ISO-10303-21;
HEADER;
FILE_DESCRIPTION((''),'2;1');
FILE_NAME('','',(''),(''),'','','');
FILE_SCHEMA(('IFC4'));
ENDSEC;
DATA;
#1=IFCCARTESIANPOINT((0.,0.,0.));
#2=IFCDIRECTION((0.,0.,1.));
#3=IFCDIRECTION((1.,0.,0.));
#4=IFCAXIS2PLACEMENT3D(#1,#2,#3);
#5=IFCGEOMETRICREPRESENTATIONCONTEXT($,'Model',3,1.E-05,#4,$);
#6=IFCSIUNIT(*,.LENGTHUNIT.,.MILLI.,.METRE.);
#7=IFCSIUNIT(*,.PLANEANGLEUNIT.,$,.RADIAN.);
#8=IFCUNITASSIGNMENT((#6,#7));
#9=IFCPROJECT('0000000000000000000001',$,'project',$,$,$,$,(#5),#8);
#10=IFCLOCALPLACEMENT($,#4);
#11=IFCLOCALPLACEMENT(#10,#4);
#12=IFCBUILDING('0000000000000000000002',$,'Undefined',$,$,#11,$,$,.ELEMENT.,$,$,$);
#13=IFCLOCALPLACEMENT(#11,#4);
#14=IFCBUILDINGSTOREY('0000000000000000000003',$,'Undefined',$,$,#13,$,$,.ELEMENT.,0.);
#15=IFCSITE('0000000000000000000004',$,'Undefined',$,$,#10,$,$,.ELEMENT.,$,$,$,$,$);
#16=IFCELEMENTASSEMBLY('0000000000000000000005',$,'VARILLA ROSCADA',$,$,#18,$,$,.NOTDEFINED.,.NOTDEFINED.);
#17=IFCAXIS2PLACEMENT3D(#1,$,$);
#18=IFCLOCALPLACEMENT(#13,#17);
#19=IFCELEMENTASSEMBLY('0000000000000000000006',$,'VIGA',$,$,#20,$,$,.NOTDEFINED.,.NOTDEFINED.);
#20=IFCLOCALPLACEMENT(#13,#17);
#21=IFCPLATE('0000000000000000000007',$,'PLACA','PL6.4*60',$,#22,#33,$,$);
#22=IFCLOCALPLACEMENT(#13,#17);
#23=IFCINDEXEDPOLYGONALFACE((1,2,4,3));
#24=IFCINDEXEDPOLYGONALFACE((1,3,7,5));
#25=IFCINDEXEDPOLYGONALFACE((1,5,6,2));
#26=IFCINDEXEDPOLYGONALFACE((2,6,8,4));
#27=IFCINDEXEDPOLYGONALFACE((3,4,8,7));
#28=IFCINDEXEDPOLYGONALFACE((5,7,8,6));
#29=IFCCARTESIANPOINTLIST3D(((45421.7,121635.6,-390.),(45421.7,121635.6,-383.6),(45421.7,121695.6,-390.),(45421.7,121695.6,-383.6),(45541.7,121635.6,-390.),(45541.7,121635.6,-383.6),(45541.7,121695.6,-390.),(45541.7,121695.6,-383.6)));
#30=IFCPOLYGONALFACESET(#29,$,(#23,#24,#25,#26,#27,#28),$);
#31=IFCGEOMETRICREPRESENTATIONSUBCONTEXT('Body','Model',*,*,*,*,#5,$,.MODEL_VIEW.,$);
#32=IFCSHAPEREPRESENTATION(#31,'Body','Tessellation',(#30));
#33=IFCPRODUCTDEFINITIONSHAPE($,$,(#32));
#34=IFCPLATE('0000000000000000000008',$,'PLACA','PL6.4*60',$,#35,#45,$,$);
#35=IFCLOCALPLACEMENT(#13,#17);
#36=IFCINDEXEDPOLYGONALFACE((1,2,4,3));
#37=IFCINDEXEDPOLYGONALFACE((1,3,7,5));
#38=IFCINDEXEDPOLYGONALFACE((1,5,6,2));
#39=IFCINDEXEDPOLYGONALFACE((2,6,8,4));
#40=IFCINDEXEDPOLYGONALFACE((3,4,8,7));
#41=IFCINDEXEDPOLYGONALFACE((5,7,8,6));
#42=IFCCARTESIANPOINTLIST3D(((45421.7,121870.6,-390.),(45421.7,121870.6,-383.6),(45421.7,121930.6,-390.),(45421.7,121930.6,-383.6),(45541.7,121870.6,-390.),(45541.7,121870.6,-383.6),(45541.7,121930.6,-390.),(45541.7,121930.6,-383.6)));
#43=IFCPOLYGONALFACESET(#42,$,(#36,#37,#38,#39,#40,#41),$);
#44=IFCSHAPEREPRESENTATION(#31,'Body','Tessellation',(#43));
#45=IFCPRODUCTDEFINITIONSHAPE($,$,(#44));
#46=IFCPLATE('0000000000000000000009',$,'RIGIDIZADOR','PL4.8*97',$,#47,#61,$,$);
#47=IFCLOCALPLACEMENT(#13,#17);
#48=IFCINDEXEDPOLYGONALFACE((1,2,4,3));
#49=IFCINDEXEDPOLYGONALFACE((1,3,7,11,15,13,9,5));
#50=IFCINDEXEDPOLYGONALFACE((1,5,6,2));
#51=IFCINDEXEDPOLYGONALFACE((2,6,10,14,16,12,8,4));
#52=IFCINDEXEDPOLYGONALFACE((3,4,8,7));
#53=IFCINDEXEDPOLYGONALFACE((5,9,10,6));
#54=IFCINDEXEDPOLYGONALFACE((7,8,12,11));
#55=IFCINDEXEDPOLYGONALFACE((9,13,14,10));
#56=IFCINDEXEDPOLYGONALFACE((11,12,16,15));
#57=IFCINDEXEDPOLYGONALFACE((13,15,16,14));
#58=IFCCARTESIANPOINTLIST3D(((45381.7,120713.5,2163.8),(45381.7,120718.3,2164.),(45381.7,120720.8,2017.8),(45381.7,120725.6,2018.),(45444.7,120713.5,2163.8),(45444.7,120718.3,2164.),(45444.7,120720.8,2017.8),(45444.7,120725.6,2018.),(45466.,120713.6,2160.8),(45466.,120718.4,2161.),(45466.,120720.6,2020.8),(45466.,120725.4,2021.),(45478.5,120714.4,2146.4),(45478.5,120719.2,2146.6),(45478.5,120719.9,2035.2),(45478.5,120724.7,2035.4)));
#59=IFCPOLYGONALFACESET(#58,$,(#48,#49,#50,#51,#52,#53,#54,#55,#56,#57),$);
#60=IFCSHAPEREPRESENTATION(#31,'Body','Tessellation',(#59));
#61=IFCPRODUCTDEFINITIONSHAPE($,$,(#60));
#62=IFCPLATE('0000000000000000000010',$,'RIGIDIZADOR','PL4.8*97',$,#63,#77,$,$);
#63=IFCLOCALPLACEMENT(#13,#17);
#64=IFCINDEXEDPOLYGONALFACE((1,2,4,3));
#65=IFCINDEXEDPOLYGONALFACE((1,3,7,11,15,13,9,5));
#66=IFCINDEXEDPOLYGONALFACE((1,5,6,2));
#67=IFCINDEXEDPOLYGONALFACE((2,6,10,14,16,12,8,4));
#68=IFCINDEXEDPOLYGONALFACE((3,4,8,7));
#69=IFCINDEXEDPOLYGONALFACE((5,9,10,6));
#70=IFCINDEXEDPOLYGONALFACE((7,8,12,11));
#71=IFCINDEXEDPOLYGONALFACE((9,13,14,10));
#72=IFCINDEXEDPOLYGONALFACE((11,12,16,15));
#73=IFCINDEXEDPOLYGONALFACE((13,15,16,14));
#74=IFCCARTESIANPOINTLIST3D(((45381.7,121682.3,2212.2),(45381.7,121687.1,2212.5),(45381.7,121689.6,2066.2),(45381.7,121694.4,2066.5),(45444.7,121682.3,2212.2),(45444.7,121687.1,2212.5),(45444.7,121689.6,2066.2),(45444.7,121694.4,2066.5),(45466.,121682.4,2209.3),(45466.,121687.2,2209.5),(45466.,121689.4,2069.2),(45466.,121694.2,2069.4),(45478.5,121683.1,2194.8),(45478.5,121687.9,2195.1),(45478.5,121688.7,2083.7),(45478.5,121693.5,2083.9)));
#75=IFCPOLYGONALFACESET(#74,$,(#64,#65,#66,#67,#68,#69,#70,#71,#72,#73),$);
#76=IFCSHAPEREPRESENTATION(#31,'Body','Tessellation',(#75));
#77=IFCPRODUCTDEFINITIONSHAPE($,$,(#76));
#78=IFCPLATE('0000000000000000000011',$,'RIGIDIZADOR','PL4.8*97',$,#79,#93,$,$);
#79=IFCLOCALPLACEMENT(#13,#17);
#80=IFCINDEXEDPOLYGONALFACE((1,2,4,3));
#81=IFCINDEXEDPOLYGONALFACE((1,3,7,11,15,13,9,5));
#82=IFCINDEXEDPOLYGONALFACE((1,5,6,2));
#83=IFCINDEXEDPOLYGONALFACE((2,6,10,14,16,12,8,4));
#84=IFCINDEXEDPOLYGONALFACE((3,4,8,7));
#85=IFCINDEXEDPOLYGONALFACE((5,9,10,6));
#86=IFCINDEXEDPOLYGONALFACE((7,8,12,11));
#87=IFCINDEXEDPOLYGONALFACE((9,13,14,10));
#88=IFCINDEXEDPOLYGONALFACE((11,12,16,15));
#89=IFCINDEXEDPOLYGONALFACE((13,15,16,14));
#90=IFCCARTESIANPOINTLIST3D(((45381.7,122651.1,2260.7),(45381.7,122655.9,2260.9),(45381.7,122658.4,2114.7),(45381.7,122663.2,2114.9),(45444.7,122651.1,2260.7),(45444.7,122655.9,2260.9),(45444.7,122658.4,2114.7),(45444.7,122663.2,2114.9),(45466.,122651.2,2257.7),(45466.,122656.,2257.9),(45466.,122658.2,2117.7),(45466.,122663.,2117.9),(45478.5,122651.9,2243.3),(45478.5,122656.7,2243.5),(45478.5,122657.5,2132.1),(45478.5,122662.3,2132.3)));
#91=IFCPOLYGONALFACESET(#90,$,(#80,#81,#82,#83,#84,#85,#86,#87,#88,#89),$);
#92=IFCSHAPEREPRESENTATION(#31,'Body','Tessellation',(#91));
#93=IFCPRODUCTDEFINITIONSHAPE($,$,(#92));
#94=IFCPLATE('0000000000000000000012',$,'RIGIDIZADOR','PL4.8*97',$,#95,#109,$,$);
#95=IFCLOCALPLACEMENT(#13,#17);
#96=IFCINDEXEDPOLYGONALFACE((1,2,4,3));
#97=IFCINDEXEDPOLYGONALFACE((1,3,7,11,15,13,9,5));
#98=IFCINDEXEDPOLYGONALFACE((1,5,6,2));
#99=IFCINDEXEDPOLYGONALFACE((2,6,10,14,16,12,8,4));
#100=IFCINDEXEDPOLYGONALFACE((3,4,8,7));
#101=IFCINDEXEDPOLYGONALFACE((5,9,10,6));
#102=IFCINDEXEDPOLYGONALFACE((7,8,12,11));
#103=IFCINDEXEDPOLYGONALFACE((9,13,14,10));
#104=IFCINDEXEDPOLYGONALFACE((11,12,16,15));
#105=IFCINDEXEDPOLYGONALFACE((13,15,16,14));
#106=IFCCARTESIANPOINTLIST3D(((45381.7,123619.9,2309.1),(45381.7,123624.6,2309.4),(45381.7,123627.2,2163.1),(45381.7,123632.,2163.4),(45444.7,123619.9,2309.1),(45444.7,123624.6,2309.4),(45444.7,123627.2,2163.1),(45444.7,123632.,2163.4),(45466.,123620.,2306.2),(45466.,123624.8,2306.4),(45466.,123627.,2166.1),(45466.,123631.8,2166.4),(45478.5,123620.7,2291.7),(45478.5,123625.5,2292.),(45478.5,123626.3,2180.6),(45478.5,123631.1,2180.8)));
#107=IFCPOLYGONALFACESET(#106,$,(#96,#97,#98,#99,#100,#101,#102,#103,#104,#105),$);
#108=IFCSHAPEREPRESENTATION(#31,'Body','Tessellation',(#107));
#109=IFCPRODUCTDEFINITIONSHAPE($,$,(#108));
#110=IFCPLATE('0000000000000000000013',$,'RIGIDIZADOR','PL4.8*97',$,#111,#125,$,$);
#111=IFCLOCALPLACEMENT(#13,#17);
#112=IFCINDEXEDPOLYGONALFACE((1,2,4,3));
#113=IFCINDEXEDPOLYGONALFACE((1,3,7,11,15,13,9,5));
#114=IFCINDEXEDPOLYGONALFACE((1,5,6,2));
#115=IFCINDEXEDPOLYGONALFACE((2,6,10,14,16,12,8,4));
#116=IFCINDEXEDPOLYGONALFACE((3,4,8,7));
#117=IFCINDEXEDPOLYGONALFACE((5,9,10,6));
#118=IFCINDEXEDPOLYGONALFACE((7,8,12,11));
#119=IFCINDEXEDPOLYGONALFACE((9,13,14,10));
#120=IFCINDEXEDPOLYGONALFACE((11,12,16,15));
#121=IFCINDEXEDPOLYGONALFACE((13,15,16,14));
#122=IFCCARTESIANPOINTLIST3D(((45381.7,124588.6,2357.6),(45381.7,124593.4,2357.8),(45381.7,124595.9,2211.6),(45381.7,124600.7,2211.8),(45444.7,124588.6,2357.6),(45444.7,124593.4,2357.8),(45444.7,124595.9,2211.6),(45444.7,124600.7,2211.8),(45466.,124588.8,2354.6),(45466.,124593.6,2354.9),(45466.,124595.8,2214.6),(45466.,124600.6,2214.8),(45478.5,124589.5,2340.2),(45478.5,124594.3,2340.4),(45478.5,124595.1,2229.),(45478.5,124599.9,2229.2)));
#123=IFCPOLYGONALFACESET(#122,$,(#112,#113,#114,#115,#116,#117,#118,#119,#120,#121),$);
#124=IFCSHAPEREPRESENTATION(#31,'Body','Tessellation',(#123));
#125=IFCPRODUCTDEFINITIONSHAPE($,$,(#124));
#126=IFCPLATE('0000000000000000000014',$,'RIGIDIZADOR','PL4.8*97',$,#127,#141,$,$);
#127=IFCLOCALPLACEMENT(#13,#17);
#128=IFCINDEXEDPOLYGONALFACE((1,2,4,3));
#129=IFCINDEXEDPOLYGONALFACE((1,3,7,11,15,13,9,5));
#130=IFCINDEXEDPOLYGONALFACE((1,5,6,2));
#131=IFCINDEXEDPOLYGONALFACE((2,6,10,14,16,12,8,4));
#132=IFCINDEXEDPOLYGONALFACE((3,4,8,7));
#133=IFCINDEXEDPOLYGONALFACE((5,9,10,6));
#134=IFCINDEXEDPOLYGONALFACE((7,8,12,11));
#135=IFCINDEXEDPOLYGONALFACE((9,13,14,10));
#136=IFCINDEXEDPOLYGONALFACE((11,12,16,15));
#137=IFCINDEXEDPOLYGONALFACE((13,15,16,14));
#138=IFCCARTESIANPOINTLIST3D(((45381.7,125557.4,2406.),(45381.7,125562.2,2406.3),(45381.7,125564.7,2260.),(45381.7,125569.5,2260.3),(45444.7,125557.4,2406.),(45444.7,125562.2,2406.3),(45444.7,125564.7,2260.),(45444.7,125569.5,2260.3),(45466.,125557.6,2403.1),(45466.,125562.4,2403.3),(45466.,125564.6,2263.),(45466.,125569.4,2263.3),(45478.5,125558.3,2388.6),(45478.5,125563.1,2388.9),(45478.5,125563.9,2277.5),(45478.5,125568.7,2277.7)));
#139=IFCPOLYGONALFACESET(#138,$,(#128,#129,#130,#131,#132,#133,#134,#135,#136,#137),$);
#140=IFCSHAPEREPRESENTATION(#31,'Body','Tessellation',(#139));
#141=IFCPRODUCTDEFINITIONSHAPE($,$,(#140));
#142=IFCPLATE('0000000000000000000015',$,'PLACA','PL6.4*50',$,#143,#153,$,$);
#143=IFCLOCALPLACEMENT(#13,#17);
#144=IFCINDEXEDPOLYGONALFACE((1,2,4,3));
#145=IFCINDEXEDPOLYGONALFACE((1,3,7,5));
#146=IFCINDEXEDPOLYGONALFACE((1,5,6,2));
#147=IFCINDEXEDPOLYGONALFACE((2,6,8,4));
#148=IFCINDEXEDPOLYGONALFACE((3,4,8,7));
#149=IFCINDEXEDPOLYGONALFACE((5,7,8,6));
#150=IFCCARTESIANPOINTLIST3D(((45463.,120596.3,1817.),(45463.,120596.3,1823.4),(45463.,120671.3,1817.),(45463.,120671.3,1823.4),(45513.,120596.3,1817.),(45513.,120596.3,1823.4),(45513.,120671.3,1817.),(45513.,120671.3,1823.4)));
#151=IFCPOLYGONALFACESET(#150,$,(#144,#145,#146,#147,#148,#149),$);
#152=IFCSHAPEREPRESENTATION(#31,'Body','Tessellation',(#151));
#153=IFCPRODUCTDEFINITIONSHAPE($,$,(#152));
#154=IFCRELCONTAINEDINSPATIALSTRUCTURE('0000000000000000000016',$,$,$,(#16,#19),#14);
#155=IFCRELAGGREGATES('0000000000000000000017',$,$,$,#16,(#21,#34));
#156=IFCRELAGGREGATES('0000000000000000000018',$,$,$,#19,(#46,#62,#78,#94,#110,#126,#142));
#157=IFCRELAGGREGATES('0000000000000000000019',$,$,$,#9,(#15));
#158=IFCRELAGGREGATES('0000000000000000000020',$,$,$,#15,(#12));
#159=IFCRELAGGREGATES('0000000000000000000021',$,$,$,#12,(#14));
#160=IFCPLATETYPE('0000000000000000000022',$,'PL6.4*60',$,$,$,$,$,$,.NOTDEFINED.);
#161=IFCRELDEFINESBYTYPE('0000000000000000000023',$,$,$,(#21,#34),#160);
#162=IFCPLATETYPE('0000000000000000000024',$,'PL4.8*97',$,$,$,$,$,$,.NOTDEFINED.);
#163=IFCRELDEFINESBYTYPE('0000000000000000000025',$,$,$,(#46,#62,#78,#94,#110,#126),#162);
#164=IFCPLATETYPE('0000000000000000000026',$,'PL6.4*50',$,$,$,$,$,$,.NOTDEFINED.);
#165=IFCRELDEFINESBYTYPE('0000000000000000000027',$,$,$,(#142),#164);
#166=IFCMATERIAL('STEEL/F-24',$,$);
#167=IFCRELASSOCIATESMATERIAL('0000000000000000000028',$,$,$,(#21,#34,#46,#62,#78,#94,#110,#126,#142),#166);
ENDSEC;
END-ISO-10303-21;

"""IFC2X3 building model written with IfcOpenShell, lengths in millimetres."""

from ifc_helpers import new_model, si_unit, frame, origin_with_axes, place, context, subcontext, project, spatial, polyline, outline, extrude, material, type_object, element, aggregate, save


model = new_model("IFC2X3")

# Units and contexts
model_context = context("Model", 3, precision=1e-05, world=origin_with_axes())
body_context = subcontext(model_context, "Body", "Model", "MODEL_VIEW")
ifc_project = project(units=[si_unit("LENGTHUNIT", "METRE", prefix="MILLI"), si_unit("PLANEANGLEUNIT", "RADIAN")], contexts=[model_context])

# Site, building, storey
site_placement = place(None, origin_with_axes())
site = spatial("IfcSite", under=ifc_project, at=site_placement, Name="Undefined", CompositionType="ELEMENT")
building_placement = place(site_placement, origin_with_axes())
building = spatial("IfcBuilding", under=site, at=building_placement, Name="Undefined", CompositionType="ELEMENT")
storey_placement = place(building_placement, origin_with_axes())
storey = spatial("IfcBuildingStorey", under=building, at=storey_placement, Name="Undefined", CompositionType="ELEMENT", Elevation=0.0)

# Element assembly
assembly_1_placement = place(storey_placement, origin_with_axes())
assembly_1 = element("IfcElementAssembly", 1, at=assembly_1_placement, inside=storey, Name="VARILLA ROSCADA", AssemblyPlace="NOTDEFINED", PredefinedType="NOTDEFINED")

# Element assembly
assembly_2_placement = place(storey_placement, origin_with_axes())
assembly_2 = element("IfcElementAssembly", 2, at=assembly_2_placement, inside=storey, Name="VIGA", AssemblyPlace="NOTDEFINED", PredefinedType="NOTDEFINED")
ifc_material_1 = material(Name="STEEL/F-24")

# Plates
plate_type_1 = type_object("IfcPlateType", Name="PL6.4*60", PredefinedType="NOTDEFINED")
plate_1_placement = place(assembly_1_placement, frame((45421.7, 121635.6, -386.8), z_axis=(0.0, 0.0, 1.0), x_axis=(1.0, 0.0, 0.0)))
plate_1 = element("IfcPlate", 3, at=plate_1_placement, type_object=plate_type_1, material=ifc_material_1, Name="PLACA", Description="PL6.4*60", context=body_context, shape_type="SweptSolid", body=[
    extrude(outline(polyline([(0.0, 0.0), (120.0, 0.0), (120.0, 60.0), (0.0, 60.0), (0.0, 0.0)])), frame((0.0, 0.0, -3.2), z_axis=(0.0, 0.0, 1.0), x_axis=(1.0, 0.0, 0.0)), (0.0, 0.0, 1.0), 6.4),
])
plate_2_placement = place(assembly_1_placement, frame((45421.7, 121870.6, -386.8), z_axis=(0.0, 0.0, 1.0), x_axis=(1.0, 0.0, 0.0)))
plate_2 = element("IfcPlate", 4, at=plate_2_placement, type_object=plate_type_1, material=ifc_material_1, Name="PLACA", Description="PL6.4*60", context=body_context, shape_type="SweptSolid", body=[
    extrude(outline(polyline([(0.0, 0.0), (120.0, 0.0), (120.0, 60.0), (0.0, 60.0), (0.0, 0.0)])), frame((0.0, 0.0, -3.2), z_axis=(0.0, 0.0, 1.0), x_axis=(1.0, 0.0, 0.0)), (0.0, 0.0, 1.0), 6.4),
])
plate_type_2 = type_object("IfcPlateType", Name="PL4.8*97", PredefinedType="NOTDEFINED")
plate_3_placement = place(assembly_2_placement, frame((45381.7, 120715.9, 2163.9), z_axis=(0.0, 0.998752, 0.04995), x_axis=(1.0, 0.0, 0.0)))
plate_3 = element("IfcPlate", 5, at=plate_3_placement, type_object=plate_type_2, material=ifc_material_1, Name="RIGIDIZADOR", Description="PL4.8*97", context=body_context, shape_type="SweptSolid", body=[
    extrude(outline(polyline([(0.0, 0.0), (63.0, 0.0), (84.3, 3.0), (96.8, 17.4), (96.8, 128.7), (84.3, 143.2), (63.0, 146.2), (0.0, 146.2), (0.0, 0.0)])), frame((0.0, 0.0, -2.4), z_axis=(0.0, 0.0, 1.0), x_axis=(1.0, 0.0, 0.0)), (0.0, 0.0, 1.0), 4.8),
])
plate_4_placement = place(assembly_2_placement, frame((45381.7, 121684.7, 2212.4), z_axis=(0.0, 0.998752, 0.04995), x_axis=(1.0, 0.0, 0.0)))
plate_4 = element("IfcPlate", 6, at=plate_4_placement, type_object=plate_type_2, material=ifc_material_1, Name="RIGIDIZADOR", Description="PL4.8*97", context=body_context, shape_type="SweptSolid", body=[
    extrude(outline(polyline([(0.0, 0.0), (63.0, 0.0), (84.3, 3.0), (96.8, 17.4), (96.8, 128.7), (84.3, 143.2), (63.0, 146.2), (0.0, 146.2), (0.0, 0.0)])), frame((0.0, 0.0, -2.4), z_axis=(0.0, 0.0, 1.0), x_axis=(1.0, 0.0, 0.0)), (0.0, 0.0, 1.0), 4.8),
])
plate_5_placement = place(assembly_2_placement, frame((45381.7, 122653.5, 2260.8), z_axis=(0.0, 0.998752, 0.04995), x_axis=(1.0, 0.0, 0.0)))
plate_5 = element("IfcPlate", 7, at=plate_5_placement, type_object=plate_type_2, material=ifc_material_1, Name="RIGIDIZADOR", Description="PL4.8*97", context=body_context, shape_type="SweptSolid", body=[
    extrude(outline(polyline([(0.0, 0.0), (63.0, 0.0), (84.3, 3.0), (96.8, 17.4), (96.8, 128.7), (84.3, 143.2), (63.0, 146.2), (0.0, 146.2), (0.0, 0.0)])), frame((0.0, 0.0, -2.4), z_axis=(0.0, 0.0, 1.0), x_axis=(1.0, 0.0, 0.0)), (0.0, 0.0, 1.0), 4.8),
])
plate_6_placement = place(assembly_2_placement, frame((45381.7, 123622.3, 2309.3), z_axis=(0.0, 0.998752, 0.04995), x_axis=(1.0, 0.0, 0.0)))
plate_6 = element("IfcPlate", 8, at=plate_6_placement, type_object=plate_type_2, material=ifc_material_1, Name="RIGIDIZADOR", Description="PL4.8*97", context=body_context, shape_type="SweptSolid", body=[
    extrude(outline(polyline([(0.0, 0.0), (63.0, 0.0), (84.3, 3.0), (96.8, 17.4), (96.8, 128.7), (84.3, 143.2), (63.0, 146.2), (0.0, 146.2), (0.0, 0.0)])), frame((0.0, 0.0, -2.4), z_axis=(0.0, 0.0, 1.0), x_axis=(1.0, 0.0, 0.0)), (0.0, 0.0, 1.0), 4.8),
])
plate_7_placement = place(assembly_2_placement, frame((45381.7, 124591.0, 2357.7), z_axis=(0.0, 0.998752, 0.04995), x_axis=(1.0, 0.0, 0.0)))
plate_7 = element("IfcPlate", 9, at=plate_7_placement, type_object=plate_type_2, material=ifc_material_1, Name="RIGIDIZADOR", Description="PL4.8*97", context=body_context, shape_type="SweptSolid", body=[
    extrude(outline(polyline([(0.0, 0.0), (63.0, 0.0), (84.3, 3.0), (96.8, 17.4), (96.8, 128.7), (84.3, 143.2), (63.0, 146.2), (0.0, 146.2), (0.0, 0.0)])), frame((0.0, 0.0, -2.4), z_axis=(0.0, 0.0, 1.0), x_axis=(1.0, 0.0, 0.0)), (0.0, 0.0, 1.0), 4.8),
])
plate_8_placement = place(assembly_2_placement, frame((45381.7, 125559.8, 2406.2), z_axis=(0.0, 0.998752, 0.04995), x_axis=(1.0, 0.0, 0.0)))
plate_8 = element("IfcPlate", 10, at=plate_8_placement, type_object=plate_type_2, material=ifc_material_1, Name="RIGIDIZADOR", Description="PL4.8*97", context=body_context, shape_type="SweptSolid", body=[
    extrude(outline(polyline([(0.0, 0.0), (63.0, 0.0), (84.3, 3.0), (96.8, 17.4), (96.8, 128.7), (84.3, 143.2), (63.0, 146.2), (0.0, 146.2), (0.0, 0.0)])), frame((0.0, 0.0, -2.4), z_axis=(0.0, 0.0, 1.0), x_axis=(1.0, 0.0, 0.0)), (0.0, 0.0, 1.0), 4.8),
])
plate_type_3 = type_object("IfcPlateType", Name="PL6.4*50", PredefinedType="NOTDEFINED")
plate_9_placement = place(assembly_2_placement, frame((45463.0, 120671.3, 1820.2), z_axis=(0.0, 0.0, 1.0), x_axis=(0.0, -1.0, 0.0)))
plate_9 = element("IfcPlate", 11, at=plate_9_placement, type_object=plate_type_3, material=ifc_material_1, Name="PLACA", Description="PL6.4*50", context=body_context, shape_type="SweptSolid", body=[
    extrude(outline(polyline([(0.0, 0.0), (75.0, 0.0), (75.0, 50.0), (0.0, 50.0), (0.0, 0.0)])), frame((0.0, 0.0, -3.2), z_axis=(0.0, 0.0, 1.0), x_axis=(1.0, 0.0, 0.0)), (0.0, 0.0, 1.0), 6.4),
])

aggregate(assembly_1, [plate_1, plate_2])
aggregate(assembly_2, [plate_3, plate_4, plate_5, plate_6, plate_7, plate_8, plate_9])

save(model, "model.ifc")
